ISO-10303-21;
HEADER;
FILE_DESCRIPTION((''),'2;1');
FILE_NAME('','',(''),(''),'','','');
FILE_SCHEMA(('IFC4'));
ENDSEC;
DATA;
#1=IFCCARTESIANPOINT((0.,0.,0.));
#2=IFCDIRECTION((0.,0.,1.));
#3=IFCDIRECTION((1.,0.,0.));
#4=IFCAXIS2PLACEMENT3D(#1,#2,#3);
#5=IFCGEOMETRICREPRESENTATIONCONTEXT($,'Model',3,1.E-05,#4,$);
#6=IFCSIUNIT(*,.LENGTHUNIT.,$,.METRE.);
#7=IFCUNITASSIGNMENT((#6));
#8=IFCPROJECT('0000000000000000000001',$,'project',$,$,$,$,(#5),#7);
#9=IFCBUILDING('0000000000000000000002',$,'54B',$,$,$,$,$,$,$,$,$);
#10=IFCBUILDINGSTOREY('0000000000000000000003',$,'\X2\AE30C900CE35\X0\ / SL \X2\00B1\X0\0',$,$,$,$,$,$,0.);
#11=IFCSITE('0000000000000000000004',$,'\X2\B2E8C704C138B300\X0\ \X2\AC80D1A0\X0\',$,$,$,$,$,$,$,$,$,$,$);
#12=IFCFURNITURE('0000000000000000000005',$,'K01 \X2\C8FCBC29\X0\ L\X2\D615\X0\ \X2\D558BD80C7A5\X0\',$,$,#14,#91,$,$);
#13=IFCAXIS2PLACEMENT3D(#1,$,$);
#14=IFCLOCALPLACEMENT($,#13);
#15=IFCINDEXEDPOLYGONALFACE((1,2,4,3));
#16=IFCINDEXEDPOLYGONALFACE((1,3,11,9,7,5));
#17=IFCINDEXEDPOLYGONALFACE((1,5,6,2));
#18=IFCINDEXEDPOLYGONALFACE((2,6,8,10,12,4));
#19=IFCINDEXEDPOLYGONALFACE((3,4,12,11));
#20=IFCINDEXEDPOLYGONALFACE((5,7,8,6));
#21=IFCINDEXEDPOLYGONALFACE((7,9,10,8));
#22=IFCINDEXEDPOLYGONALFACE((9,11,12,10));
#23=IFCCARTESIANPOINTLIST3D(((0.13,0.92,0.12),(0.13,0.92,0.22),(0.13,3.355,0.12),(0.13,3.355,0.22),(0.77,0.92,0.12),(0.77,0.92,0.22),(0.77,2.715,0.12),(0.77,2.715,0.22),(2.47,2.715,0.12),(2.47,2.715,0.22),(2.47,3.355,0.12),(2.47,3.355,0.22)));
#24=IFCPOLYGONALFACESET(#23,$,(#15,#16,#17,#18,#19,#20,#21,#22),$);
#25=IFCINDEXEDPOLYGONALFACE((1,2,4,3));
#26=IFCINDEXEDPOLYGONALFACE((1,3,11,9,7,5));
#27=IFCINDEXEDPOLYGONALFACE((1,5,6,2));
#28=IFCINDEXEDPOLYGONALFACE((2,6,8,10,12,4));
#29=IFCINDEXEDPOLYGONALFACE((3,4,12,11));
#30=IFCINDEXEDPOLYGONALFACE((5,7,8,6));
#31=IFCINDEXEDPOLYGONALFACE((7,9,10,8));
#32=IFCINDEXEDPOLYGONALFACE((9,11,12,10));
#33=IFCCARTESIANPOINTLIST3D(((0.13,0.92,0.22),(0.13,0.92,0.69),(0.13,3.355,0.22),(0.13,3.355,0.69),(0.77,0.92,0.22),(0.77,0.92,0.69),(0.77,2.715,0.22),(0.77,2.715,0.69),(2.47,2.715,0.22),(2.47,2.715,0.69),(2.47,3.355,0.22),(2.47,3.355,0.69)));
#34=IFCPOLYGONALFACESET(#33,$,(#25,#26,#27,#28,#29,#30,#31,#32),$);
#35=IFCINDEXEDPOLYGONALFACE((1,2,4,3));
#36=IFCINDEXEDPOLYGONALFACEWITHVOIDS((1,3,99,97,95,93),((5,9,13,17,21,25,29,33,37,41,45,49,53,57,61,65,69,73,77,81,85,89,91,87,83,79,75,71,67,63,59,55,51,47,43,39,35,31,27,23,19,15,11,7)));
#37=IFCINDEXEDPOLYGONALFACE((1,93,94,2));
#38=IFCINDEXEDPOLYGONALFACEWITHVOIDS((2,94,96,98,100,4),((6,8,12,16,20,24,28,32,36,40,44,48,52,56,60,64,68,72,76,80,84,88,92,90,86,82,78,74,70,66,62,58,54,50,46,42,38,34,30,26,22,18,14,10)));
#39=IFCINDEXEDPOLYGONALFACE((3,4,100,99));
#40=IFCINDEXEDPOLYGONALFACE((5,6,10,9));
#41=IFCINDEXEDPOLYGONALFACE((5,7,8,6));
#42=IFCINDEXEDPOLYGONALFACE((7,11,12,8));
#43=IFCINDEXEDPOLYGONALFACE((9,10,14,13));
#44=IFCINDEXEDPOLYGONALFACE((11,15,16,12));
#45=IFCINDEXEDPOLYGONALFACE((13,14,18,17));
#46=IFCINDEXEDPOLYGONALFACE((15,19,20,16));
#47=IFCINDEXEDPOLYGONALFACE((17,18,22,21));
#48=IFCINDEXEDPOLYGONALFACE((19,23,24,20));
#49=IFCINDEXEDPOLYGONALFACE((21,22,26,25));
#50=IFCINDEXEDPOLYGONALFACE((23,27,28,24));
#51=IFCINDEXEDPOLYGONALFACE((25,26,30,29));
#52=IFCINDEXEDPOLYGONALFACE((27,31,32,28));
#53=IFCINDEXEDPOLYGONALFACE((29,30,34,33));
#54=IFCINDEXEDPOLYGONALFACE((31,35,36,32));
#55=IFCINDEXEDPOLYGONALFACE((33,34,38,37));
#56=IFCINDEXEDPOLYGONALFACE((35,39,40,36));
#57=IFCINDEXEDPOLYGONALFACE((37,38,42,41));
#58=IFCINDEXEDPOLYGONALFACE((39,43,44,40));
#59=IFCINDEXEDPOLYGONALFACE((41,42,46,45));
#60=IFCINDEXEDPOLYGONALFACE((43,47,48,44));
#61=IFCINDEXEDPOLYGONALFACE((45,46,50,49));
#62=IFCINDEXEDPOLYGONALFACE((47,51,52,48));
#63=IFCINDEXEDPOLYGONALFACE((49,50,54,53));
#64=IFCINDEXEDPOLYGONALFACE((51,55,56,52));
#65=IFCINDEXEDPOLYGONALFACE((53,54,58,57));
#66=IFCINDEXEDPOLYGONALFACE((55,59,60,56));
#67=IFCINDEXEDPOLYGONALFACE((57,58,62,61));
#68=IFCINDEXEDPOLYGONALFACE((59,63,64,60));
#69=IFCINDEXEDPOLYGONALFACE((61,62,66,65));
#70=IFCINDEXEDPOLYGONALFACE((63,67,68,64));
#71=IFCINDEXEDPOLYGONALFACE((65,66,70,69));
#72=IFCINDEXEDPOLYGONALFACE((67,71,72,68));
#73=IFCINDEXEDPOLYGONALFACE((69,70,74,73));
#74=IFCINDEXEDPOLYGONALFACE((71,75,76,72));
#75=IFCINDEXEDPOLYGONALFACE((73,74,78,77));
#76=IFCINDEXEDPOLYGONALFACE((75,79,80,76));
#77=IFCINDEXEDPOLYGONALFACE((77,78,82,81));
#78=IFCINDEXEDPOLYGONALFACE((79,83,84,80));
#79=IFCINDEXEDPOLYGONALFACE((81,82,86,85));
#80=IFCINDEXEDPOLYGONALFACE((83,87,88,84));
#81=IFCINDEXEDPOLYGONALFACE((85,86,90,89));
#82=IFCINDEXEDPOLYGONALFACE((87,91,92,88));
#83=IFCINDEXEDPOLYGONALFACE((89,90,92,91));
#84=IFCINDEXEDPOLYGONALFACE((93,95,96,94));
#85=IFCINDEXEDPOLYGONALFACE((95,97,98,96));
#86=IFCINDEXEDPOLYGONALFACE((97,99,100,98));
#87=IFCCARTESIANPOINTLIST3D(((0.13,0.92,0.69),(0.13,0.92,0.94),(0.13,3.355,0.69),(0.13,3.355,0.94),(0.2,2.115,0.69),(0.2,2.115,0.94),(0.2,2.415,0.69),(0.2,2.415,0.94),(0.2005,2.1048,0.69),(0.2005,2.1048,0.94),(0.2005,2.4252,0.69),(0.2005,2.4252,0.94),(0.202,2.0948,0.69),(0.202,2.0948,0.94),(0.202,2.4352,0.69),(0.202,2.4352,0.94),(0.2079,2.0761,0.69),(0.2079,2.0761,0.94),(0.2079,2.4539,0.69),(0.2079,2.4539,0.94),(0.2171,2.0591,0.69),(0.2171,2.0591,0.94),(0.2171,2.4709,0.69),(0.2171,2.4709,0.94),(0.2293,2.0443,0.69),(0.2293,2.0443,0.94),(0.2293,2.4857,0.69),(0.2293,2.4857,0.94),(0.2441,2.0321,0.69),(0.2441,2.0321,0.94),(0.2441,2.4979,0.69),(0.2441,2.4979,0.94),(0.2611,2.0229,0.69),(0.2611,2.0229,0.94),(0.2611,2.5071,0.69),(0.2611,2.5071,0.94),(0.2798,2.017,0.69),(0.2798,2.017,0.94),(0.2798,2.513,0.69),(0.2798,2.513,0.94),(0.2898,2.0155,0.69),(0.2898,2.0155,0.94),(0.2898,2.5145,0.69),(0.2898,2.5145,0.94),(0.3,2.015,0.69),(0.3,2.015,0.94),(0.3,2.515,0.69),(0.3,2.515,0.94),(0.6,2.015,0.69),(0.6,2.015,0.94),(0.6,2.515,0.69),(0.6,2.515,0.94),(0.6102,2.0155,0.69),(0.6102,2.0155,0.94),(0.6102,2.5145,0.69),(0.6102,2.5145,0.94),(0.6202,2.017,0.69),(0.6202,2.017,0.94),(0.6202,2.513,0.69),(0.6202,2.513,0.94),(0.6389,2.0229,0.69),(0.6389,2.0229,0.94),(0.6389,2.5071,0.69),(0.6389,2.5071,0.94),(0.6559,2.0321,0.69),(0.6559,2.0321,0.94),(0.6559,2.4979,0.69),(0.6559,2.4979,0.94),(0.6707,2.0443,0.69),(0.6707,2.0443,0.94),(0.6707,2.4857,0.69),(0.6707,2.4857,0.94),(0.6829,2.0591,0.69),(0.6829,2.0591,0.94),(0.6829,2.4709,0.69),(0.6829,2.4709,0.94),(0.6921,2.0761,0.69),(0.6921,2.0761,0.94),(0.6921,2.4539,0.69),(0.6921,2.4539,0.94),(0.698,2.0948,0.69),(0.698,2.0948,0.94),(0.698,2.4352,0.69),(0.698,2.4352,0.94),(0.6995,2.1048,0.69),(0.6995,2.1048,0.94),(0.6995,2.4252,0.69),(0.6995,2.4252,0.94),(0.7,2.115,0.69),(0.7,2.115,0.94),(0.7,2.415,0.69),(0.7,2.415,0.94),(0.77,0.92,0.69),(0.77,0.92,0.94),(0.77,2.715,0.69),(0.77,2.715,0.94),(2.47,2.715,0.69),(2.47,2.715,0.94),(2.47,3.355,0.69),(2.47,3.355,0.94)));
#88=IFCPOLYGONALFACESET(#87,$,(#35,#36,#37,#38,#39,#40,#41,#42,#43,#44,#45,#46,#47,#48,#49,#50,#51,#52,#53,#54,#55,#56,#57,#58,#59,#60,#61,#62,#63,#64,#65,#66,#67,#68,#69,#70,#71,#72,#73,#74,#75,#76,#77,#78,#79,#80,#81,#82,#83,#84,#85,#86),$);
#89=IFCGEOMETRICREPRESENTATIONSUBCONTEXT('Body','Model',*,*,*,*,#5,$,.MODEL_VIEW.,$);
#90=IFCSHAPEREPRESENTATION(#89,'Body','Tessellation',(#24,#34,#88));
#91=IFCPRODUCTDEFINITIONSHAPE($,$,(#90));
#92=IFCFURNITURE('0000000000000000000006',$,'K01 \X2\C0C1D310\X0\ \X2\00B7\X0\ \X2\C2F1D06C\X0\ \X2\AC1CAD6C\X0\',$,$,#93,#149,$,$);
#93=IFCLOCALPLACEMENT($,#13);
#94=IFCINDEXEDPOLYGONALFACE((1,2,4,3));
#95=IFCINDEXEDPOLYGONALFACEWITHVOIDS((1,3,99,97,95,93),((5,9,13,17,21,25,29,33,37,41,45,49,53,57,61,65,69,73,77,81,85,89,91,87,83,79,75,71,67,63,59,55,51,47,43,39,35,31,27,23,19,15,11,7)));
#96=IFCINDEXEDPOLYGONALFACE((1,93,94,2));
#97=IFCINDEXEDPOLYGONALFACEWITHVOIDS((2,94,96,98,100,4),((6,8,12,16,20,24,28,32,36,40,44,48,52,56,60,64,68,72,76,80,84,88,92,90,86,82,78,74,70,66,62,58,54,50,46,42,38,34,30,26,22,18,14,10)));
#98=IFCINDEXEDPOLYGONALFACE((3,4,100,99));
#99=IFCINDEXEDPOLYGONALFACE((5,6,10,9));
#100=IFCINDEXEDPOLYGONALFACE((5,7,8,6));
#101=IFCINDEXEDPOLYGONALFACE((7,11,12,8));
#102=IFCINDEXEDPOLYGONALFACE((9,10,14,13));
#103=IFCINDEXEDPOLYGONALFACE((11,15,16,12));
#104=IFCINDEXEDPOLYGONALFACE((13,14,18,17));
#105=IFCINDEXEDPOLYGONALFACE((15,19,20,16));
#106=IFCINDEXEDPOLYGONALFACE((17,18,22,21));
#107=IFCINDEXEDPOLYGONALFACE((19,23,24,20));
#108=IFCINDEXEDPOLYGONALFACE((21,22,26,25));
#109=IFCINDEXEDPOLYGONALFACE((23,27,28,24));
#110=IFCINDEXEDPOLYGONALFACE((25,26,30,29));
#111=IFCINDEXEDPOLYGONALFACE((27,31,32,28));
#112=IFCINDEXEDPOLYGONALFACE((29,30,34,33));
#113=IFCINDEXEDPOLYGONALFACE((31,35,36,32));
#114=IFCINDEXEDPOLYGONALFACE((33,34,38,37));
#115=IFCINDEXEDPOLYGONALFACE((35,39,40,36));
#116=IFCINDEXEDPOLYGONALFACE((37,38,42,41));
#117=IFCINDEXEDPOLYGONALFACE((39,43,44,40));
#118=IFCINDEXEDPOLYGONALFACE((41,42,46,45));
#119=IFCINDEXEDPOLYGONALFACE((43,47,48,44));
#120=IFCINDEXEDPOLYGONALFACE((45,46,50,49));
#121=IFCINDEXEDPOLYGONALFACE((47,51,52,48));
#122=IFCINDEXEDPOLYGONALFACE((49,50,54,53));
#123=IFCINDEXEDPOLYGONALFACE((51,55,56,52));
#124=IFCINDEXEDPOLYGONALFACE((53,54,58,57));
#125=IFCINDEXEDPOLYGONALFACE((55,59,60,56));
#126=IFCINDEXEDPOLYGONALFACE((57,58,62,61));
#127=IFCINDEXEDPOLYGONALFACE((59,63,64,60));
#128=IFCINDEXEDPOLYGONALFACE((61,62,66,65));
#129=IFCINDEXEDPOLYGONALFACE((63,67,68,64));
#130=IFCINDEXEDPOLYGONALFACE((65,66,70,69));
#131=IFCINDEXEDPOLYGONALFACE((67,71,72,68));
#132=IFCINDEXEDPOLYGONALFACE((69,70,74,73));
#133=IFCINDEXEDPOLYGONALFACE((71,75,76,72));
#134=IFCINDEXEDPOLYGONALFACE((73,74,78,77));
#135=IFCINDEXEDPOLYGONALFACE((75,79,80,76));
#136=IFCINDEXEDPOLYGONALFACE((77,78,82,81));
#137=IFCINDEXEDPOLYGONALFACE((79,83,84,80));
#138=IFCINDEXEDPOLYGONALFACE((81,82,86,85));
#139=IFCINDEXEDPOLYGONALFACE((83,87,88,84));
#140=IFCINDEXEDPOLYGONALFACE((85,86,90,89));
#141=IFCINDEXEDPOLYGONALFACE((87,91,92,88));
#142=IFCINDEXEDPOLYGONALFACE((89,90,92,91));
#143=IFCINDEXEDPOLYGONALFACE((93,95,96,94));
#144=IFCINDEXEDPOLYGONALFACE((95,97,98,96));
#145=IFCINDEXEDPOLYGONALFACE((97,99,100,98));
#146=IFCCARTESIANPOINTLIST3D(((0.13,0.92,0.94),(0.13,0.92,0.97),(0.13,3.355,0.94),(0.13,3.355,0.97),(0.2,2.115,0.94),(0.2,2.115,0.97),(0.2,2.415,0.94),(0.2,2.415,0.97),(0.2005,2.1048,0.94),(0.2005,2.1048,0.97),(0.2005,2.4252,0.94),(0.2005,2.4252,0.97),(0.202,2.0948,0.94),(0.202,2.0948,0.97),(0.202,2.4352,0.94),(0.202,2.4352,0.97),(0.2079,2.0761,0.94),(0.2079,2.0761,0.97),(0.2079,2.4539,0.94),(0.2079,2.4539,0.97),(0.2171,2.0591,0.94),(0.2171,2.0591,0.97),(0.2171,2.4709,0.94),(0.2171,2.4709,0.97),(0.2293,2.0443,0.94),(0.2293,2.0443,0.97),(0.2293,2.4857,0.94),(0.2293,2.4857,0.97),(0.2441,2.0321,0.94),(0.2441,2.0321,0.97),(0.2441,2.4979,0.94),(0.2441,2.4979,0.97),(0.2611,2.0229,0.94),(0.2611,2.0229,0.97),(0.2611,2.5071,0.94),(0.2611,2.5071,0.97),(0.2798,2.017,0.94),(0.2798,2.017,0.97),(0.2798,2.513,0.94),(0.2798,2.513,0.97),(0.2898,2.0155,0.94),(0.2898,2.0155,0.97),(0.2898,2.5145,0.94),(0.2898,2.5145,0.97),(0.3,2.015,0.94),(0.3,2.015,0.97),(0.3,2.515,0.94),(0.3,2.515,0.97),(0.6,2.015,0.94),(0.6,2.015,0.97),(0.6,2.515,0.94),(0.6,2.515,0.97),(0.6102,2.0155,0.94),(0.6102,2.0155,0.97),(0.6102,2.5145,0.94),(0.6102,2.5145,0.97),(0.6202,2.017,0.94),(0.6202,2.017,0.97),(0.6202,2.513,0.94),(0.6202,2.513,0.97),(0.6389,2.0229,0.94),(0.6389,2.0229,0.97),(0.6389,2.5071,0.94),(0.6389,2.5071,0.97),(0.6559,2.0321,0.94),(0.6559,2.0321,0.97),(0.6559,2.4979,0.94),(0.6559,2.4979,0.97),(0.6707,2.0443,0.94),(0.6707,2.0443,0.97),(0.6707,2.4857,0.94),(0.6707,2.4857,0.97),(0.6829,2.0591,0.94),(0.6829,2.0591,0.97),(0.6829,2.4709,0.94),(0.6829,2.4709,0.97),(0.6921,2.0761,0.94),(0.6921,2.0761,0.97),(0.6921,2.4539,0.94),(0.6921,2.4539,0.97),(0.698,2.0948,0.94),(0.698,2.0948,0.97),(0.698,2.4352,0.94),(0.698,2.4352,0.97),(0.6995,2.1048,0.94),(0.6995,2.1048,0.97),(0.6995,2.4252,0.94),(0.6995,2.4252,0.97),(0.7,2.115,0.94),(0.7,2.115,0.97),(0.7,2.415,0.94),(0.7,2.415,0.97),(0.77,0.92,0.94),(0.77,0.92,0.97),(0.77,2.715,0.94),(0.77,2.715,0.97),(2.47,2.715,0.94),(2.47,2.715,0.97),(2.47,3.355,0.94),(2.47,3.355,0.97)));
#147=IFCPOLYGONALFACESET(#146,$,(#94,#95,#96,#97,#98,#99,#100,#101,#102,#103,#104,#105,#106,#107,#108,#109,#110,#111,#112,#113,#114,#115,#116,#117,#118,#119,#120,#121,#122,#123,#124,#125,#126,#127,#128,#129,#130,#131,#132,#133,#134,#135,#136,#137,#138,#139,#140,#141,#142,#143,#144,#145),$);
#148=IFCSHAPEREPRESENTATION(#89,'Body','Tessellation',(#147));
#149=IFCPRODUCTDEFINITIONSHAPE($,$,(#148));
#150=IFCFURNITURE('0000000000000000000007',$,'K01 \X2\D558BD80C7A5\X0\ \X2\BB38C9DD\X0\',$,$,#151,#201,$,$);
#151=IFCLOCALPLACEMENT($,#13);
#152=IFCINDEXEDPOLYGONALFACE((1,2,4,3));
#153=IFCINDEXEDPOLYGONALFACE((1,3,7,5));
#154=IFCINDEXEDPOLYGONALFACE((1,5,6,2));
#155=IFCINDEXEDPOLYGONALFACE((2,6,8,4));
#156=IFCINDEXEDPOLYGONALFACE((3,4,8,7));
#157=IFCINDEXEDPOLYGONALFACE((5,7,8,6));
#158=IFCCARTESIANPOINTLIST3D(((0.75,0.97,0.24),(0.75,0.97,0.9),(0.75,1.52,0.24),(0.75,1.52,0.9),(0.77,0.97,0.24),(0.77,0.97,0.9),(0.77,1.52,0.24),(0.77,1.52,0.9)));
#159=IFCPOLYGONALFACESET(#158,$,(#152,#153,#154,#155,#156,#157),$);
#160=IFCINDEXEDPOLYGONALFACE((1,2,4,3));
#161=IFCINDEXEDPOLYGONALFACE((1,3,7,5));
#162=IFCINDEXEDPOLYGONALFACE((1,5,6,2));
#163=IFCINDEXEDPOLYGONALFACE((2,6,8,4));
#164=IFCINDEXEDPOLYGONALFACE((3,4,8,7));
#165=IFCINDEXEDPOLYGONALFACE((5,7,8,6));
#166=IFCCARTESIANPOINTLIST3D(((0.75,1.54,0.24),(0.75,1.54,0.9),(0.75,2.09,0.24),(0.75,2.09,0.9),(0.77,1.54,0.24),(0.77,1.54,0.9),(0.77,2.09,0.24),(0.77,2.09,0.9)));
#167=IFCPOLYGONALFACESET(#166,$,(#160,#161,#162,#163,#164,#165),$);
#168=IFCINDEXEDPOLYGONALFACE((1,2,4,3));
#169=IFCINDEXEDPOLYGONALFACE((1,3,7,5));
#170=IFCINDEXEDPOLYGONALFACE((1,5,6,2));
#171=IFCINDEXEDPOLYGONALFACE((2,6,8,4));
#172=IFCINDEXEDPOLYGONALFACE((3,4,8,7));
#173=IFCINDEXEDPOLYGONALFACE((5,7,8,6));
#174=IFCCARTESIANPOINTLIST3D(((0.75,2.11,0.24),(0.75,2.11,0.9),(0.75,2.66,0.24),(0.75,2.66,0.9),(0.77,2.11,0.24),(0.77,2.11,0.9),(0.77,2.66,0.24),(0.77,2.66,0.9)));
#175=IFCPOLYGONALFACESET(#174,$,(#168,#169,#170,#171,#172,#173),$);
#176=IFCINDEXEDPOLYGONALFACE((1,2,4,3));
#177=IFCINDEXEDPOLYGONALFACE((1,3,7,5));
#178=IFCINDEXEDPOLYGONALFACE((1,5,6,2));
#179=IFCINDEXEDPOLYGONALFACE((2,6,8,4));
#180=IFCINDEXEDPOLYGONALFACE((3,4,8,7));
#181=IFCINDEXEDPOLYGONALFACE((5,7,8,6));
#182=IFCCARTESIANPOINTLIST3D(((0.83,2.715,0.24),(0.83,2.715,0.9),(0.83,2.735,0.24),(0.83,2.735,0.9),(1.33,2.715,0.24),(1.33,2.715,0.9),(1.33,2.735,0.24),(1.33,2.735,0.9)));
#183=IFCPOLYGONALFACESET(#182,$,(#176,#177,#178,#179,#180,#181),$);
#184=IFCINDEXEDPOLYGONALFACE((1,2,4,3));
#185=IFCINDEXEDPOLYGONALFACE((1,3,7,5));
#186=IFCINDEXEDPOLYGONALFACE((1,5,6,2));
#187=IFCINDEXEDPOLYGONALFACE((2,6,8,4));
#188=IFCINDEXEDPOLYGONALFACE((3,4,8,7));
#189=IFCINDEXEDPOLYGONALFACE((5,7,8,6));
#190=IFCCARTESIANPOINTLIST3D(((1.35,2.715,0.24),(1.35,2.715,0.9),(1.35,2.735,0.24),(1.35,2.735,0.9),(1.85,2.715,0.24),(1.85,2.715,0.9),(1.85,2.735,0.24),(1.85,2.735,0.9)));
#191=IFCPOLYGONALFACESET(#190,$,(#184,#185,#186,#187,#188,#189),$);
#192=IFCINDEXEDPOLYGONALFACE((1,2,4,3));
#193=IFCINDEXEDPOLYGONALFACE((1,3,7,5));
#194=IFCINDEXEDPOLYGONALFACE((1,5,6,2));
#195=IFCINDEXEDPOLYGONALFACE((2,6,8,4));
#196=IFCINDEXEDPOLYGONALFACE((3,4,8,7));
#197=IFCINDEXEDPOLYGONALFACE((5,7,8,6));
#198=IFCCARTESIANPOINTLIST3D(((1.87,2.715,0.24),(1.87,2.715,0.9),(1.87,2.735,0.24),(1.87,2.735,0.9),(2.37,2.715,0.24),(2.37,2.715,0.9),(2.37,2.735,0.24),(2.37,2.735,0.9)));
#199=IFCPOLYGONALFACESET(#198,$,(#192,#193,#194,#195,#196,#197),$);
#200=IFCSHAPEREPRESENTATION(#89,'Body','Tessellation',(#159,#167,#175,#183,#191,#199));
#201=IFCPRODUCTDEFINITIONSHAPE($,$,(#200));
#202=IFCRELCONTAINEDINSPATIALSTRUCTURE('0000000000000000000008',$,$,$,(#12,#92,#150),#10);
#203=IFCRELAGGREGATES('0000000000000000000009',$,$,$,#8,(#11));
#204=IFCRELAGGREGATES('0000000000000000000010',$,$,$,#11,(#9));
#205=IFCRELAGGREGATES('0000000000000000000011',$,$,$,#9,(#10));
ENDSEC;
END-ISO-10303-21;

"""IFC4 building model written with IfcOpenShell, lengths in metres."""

from ifc_helpers import new_model, si_unit, frame, origin_with_axes, place, context, subcontext, project, spatial, polyline, outline, extrude, element, save


model = new_model("IFC4")

# Units and contexts
model_context = context("Model", 3, precision=1e-05, world=origin_with_axes())
body_context = subcontext(model_context, "Body", "Model", "MODEL_VIEW")
ifc_project = project(units=[si_unit("LENGTHUNIT", "METRE")], contexts=[model_context])

# Site, building, storey
site = spatial("IfcSite", under=ifc_project, Name="단위세대 검토")
building = spatial("IfcBuilding", under=site, Name="54B")
storey = spatial("IfcBuildingStorey", under=building, Name="기준층 / SL ±0", Elevation=0.0)

# Furniture
furniture_1_placement = place(None, origin_with_axes())
element("IfcFurniture", 1, at=furniture_1_placement, inside=storey, Name="K01 주방 L형 하부장", context=body_context, shape_type="SweptSolid", body=[
    extrude(outline(polyline([(0.77, 0.92), (0.13, 0.92), (0.13, 3.355), (2.47, 3.355), (2.47, 2.715), (0.77, 2.715), (0.77, 0.92)])), frame((0.0, 0.0, 0.12)), (0.0, 0.0, 1.0), 0.1),
    extrude(outline(polyline([(0.77, 0.92), (0.13, 0.92), (0.13, 3.355), (2.47, 3.355), (2.47, 2.715), (0.77, 2.715), (0.77, 0.92)])), frame((0.0, 0.0, 0.22)), (0.0, 0.0, 1.0), 0.47),
    extrude(outline(polyline([(0.13, 0.92), (0.13, 3.355), (2.47, 3.355), (2.47, 2.715), (0.77, 2.715), (0.77, 0.92), (0.13, 0.92)]), holes=[polyline([(0.6995, 2.4252), (0.698, 2.4352), (0.6921, 2.4539), (0.6829, 2.4709), (0.6707, 2.4857), (0.6559, 2.4979), (0.6389, 2.5071), (0.6202, 2.513), (0.6102, 2.5145), (0.6, 2.515), (0.3, 2.515), (0.2898, 2.5145), (0.2798, 2.513), (0.2611, 2.5071), (0.2441, 2.4979), (0.2293, 2.4857), (0.2171, 2.4709), (0.2079, 2.4539), (0.202, 2.4352), (0.2005, 2.4252), (0.2, 2.415), (0.2, 2.115), (0.2005, 2.1048), (0.202, 2.0948), (0.2079, 2.0761), (0.2171, 2.0591), (0.2293, 2.0443), (0.2441, 2.0321), (0.2611, 2.0229), (0.2798, 2.017), (0.2898, 2.0155), (0.3, 2.015), (0.6, 2.015), (0.6102, 2.0155), (0.6202, 2.017), (0.6389, 2.0229), (0.6559, 2.0321), (0.6707, 2.0443), (0.6829, 2.0591), (0.6921, 2.0761), (0.698, 2.0948), (0.6995, 2.1048), (0.7, 2.115), (0.7, 2.415), (0.6995, 2.4252)])]), frame((0.0, 0.0, 0.69)), (0.0, 0.0, 1.0), 0.25),
])
furniture_2_placement = place(None, origin_with_axes())
element("IfcFurniture", 2, at=furniture_2_placement, inside=storey, Name="K01 상판 · 싱크 개구", context=body_context, shape_type="SweptSolid", body=[
    extrude(outline(polyline([(0.13, 0.92), (0.13, 3.355), (2.47, 3.355), (2.47, 2.715), (0.77, 2.715), (0.77, 0.92), (0.13, 0.92)]), holes=[polyline([(0.6995, 2.4252), (0.698, 2.4352), (0.6921, 2.4539), (0.6829, 2.4709), (0.6707, 2.4857), (0.6559, 2.4979), (0.6389, 2.5071), (0.6202, 2.513), (0.6102, 2.5145), (0.6, 2.515), (0.3, 2.515), (0.2898, 2.5145), (0.2798, 2.513), (0.2611, 2.5071), (0.2441, 2.4979), (0.2293, 2.4857), (0.2171, 2.4709), (0.2079, 2.4539), (0.202, 2.4352), (0.2005, 2.4252), (0.2, 2.415), (0.2, 2.115), (0.2005, 2.1048), (0.202, 2.0948), (0.2079, 2.0761), (0.2171, 2.0591), (0.2293, 2.0443), (0.2441, 2.0321), (0.2611, 2.0229), (0.2798, 2.017), (0.2898, 2.0155), (0.3, 2.015), (0.6, 2.015), (0.6102, 2.0155), (0.6202, 2.017), (0.6389, 2.0229), (0.6559, 2.0321), (0.6707, 2.0443), (0.6829, 2.0591), (0.6921, 2.0761), (0.698, 2.0948), (0.6995, 2.1048), (0.7, 2.115), (0.7, 2.415), (0.6995, 2.4252)])]), frame((0.0, 0.0, 0.94)), (0.0, 0.0, 1.0), 0.03),
])
furniture_3_placement = place(None, origin_with_axes())
element("IfcFurniture", 3, at=furniture_3_placement, inside=storey, Name="K01 하부장 문짝", context=body_context, shape_type="SweptSolid", body=[
    extrude(outline(polyline([(0.77, 0.97), (0.77, 1.52), (0.75, 1.52), (0.75, 0.97), (0.77, 0.97)])), frame((0.0, 0.0, 0.24)), (0.0, 0.0, 1.0), 0.66),
    extrude(outline(polyline([(0.77, 1.54), (0.77, 2.09), (0.75, 2.09), (0.75, 1.54), (0.77, 1.54)])), frame((0.0, 0.0, 0.24)), (0.0, 0.0, 1.0), 0.66),
    extrude(outline(polyline([(0.77, 2.11), (0.77, 2.66), (0.75, 2.66), (0.75, 2.11), (0.77, 2.11)])), frame((0.0, 0.0, 0.24)), (0.0, 0.0, 1.0), 0.66),
    extrude(outline(polyline([(1.33, 2.715), (1.33, 2.735), (0.83, 2.735), (0.83, 2.715), (1.33, 2.715)])), frame((0.0, 0.0, 0.24)), (0.0, 0.0, 1.0), 0.66),
    extrude(outline(polyline([(1.85, 2.715), (1.85, 2.735), (1.35, 2.735), (1.35, 2.715), (1.85, 2.715)])), frame((0.0, 0.0, 0.24)), (0.0, 0.0, 1.0), 0.66),
    extrude(outline(polyline([(2.37, 2.715), (2.37, 2.735), (1.87, 2.735), (1.87, 2.715), (2.37, 2.715)])), frame((0.0, 0.0, 0.24)), (0.0, 0.0, 1.0), 0.66),
])

save(model, "model.ifc")
